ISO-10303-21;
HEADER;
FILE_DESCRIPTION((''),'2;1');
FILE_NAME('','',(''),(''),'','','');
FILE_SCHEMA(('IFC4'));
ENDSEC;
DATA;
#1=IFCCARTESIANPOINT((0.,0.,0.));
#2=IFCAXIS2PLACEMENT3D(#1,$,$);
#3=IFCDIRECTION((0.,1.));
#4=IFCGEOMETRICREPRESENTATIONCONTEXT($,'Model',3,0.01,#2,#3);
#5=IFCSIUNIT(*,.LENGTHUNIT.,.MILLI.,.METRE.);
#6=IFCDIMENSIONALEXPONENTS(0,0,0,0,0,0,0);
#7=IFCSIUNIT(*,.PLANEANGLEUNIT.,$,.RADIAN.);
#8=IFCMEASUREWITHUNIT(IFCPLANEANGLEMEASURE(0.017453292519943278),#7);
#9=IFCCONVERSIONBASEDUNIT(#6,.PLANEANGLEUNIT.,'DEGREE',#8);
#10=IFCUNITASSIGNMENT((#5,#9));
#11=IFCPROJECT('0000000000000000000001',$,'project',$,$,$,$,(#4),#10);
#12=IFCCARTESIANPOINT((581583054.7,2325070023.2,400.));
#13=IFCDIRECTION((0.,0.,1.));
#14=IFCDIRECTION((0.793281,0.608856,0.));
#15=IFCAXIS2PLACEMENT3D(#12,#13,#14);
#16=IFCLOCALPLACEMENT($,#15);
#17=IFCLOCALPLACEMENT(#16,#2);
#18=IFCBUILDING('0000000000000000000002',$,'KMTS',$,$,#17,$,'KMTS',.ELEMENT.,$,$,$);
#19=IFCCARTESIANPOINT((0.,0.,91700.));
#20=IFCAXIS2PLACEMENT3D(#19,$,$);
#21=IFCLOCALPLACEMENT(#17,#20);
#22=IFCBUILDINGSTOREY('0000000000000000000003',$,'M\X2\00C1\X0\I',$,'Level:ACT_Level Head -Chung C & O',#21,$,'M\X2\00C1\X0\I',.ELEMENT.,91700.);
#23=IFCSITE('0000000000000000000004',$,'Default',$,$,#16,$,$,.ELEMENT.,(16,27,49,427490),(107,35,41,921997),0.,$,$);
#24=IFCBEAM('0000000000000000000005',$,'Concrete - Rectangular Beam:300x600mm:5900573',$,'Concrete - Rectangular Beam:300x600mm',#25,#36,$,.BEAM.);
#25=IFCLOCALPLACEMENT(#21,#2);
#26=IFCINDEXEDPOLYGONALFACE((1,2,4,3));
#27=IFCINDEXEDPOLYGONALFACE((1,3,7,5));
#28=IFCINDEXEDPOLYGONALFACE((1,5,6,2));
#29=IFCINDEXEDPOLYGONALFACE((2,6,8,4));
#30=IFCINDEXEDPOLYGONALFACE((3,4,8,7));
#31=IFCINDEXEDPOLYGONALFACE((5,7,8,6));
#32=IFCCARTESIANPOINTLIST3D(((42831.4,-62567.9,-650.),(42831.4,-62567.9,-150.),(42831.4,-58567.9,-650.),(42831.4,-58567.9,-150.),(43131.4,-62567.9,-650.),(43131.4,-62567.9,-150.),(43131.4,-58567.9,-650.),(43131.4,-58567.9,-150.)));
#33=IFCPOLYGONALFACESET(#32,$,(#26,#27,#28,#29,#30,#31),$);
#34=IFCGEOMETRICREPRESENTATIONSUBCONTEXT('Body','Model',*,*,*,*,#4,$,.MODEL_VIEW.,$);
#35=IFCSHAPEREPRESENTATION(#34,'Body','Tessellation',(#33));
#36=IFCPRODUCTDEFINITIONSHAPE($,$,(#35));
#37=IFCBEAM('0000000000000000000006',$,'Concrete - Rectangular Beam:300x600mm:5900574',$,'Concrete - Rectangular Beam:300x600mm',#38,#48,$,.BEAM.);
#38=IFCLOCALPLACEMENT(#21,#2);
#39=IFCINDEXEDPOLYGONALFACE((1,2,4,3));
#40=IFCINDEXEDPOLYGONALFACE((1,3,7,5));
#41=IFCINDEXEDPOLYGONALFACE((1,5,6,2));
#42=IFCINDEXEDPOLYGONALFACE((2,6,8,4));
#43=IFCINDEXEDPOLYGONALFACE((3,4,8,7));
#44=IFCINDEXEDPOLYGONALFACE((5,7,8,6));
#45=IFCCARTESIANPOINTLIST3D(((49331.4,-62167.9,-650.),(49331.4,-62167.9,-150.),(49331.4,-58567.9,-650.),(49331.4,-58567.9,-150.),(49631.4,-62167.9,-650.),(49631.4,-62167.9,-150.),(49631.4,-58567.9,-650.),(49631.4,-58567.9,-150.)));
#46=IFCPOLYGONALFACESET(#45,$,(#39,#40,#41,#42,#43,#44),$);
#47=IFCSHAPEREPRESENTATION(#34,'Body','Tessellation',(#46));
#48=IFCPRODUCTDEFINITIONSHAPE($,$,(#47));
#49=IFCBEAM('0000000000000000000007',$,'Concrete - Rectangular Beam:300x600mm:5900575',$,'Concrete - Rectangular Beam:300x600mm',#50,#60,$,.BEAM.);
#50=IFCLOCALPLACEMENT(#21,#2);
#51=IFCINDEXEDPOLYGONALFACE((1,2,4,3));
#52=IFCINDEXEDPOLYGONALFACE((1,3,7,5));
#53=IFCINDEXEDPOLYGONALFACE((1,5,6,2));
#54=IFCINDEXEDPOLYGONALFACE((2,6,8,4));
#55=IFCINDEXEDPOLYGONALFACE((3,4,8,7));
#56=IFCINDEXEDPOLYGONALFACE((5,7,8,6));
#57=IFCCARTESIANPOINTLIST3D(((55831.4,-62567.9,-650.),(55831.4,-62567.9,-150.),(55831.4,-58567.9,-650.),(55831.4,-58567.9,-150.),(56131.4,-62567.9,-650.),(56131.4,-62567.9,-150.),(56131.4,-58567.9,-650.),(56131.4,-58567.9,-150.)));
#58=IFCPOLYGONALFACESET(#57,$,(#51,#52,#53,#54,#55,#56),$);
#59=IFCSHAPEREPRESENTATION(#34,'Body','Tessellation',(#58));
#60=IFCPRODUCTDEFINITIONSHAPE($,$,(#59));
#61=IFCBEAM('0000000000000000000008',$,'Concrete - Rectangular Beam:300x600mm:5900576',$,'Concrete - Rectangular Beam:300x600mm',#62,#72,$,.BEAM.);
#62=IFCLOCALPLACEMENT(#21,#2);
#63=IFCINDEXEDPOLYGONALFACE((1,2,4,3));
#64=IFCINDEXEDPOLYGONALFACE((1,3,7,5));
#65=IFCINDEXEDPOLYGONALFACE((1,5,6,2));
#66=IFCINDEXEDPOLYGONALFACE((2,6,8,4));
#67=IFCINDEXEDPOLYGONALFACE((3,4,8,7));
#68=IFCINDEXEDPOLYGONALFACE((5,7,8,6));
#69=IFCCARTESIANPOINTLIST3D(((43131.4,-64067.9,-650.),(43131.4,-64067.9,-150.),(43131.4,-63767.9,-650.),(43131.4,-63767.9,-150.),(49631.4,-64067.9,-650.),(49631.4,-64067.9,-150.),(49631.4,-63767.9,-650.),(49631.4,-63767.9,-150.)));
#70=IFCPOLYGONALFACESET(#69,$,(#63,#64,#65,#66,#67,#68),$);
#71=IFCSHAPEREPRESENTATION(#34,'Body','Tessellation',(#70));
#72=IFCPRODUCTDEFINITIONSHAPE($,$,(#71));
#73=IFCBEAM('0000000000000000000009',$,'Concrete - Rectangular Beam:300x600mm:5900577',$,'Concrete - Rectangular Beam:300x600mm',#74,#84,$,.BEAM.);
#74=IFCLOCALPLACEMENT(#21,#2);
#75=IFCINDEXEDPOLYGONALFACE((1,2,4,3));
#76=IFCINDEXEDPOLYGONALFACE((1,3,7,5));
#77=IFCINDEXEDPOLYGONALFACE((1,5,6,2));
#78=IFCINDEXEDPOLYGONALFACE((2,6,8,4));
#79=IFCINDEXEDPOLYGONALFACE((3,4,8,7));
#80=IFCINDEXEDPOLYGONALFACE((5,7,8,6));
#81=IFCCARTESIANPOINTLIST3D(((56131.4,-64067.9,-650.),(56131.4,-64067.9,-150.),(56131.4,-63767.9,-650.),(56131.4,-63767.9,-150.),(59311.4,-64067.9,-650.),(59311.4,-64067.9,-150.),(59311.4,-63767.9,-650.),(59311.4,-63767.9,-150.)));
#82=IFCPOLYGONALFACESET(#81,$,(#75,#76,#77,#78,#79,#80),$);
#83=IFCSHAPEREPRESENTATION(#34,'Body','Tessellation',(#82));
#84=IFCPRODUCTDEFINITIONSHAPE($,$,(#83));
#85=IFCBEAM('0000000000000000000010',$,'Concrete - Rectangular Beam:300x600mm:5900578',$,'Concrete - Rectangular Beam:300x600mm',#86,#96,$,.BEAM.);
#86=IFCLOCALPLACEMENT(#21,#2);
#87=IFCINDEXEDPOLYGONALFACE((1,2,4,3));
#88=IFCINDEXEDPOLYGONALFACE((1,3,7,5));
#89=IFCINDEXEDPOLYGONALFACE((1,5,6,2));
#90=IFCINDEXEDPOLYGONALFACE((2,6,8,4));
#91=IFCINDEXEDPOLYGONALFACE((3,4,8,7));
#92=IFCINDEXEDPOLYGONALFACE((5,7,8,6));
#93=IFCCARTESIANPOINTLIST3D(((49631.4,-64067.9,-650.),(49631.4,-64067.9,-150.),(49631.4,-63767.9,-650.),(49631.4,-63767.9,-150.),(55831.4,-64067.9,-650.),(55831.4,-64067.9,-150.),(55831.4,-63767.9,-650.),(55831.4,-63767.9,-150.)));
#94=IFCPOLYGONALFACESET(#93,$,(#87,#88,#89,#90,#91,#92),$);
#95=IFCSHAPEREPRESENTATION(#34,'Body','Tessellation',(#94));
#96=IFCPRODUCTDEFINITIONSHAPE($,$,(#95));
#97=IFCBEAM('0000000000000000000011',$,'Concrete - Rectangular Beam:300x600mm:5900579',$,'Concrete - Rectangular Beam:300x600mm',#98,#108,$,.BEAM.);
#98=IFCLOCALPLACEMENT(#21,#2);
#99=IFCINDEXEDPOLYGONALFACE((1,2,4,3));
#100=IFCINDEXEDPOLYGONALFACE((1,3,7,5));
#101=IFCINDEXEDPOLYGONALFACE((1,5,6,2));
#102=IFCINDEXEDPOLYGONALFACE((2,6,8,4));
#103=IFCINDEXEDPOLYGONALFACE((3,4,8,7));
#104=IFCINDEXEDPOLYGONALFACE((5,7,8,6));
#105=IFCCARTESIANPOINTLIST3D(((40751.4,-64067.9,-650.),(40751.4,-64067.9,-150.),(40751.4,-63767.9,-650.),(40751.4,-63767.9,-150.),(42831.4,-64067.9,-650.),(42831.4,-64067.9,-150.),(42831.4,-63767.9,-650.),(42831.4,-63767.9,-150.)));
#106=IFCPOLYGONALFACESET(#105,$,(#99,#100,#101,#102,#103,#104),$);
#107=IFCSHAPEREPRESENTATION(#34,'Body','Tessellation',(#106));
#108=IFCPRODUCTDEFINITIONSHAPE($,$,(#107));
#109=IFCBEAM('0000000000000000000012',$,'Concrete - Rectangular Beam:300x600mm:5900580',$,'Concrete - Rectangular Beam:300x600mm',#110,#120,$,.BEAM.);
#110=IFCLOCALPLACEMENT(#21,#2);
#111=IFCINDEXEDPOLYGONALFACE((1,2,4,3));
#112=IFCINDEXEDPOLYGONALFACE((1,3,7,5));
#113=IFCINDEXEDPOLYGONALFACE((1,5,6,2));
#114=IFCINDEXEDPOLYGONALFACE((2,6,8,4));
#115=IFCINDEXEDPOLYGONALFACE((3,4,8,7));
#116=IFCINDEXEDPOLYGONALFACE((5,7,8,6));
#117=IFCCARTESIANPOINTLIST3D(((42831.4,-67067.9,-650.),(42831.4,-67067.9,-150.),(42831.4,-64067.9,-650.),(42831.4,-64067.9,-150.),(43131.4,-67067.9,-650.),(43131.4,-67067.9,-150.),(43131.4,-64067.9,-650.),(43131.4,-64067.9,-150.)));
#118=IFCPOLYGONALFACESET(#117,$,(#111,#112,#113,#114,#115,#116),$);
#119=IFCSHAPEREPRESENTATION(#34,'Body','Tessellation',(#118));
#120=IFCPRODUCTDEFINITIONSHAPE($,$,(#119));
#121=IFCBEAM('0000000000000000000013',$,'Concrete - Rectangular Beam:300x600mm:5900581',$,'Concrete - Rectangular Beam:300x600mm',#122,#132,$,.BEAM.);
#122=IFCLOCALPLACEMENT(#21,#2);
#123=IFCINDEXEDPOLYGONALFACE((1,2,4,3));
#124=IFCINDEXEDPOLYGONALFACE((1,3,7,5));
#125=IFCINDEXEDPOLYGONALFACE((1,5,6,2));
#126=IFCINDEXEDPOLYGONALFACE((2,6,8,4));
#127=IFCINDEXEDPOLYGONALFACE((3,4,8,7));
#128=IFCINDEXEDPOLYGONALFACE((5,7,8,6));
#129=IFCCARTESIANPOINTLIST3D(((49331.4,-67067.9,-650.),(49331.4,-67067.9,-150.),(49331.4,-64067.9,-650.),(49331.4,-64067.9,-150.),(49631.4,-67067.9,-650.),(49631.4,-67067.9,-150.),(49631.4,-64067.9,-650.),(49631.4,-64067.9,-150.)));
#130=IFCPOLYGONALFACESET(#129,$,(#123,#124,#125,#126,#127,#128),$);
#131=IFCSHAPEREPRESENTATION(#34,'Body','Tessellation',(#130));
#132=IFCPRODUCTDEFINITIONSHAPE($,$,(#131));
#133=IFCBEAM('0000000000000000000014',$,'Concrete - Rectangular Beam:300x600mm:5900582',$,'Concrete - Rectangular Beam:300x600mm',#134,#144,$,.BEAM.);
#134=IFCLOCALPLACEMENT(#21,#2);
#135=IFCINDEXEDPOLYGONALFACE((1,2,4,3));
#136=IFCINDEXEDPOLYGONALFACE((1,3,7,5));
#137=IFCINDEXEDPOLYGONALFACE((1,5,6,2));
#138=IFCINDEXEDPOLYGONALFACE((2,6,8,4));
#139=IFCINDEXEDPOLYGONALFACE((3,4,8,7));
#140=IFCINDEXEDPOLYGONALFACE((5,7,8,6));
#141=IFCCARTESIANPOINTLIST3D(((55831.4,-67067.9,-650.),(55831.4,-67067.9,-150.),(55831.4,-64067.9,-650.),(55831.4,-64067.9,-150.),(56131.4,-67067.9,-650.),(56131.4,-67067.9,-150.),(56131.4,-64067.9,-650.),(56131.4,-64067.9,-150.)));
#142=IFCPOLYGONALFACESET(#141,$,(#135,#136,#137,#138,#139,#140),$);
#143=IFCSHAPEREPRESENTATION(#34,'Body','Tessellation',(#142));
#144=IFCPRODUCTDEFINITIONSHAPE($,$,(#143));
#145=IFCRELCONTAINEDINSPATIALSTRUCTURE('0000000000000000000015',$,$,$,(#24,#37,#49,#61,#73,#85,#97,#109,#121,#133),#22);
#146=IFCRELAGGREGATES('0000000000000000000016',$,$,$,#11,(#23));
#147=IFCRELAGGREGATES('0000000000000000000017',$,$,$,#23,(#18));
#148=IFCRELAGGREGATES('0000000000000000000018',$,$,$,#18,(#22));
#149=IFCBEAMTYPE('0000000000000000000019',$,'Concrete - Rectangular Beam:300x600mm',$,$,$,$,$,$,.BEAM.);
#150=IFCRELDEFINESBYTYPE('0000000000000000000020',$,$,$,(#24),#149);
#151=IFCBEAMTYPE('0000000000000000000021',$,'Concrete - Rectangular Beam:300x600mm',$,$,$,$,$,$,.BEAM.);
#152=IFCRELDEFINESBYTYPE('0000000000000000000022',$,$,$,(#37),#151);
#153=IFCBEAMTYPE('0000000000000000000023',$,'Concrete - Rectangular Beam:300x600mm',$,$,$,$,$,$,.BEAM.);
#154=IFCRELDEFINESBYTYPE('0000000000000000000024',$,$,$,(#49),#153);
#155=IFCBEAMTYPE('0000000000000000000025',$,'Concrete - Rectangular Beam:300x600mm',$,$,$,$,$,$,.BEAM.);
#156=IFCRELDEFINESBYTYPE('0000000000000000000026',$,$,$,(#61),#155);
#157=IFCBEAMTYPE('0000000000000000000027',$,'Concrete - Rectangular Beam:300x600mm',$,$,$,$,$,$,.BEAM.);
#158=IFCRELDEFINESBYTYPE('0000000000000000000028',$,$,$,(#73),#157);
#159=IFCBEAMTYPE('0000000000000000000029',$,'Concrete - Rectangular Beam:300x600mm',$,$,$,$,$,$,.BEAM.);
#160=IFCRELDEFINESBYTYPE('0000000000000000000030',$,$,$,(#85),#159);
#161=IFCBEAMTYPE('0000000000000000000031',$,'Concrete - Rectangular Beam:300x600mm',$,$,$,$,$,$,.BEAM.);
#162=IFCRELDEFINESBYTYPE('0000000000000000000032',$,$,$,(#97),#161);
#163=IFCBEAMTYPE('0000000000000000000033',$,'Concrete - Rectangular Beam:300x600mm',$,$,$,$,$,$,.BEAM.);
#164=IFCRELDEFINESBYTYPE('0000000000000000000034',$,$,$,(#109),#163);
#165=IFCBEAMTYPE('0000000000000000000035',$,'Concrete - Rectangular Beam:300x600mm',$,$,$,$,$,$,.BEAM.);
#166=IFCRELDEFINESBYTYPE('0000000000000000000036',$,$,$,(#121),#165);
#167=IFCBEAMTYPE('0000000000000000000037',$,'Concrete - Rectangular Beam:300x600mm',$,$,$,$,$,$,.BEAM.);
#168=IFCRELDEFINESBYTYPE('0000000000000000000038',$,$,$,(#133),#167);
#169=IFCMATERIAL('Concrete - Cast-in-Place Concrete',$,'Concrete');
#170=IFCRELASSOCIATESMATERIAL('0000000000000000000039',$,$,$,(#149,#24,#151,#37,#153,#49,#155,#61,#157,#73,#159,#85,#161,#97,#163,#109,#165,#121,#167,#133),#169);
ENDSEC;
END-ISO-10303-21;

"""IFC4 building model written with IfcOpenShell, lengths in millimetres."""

from ifc_helpers import new_model, entity, si_unit, converted_unit, direction, frame, origin, place, context, subcontext, project, spatial, indexed_curve, outline, extrude, source, transform, mapped, material, type_object, type_shapes, element, save


model = new_model("IFC4")

# Units and contexts
model_context = context("Model", 3, precision=0.01, world=origin(), true_north=direction((0.0, 1.0)))
body_context = subcontext(model_context, "Body", "Model", "MODEL_VIEW")
ifc_project = project(units=[si_unit("LENGTHUNIT", "METRE", prefix="MILLI"), converted_unit("PLANEANGLEUNIT", "DEGREE", entity("IfcPlaneAngleMeasure", 0.017453292519943278), si_unit("PLANEANGLEUNIT", "RADIAN"), dimensions=[0, 0, 0, 0, 0, 0, 0])], contexts=[model_context])

# Site, building, storey
site_placement = place(None, frame((581583054.7, 2325070023.2, 400.0), z_axis=(0.0, 0.0, 1.0), x_axis=(0.793281, 0.608856, 0.0)))
site = spatial("IfcSite", under=ifc_project, at=site_placement, Name="Default", CompositionType="ELEMENT", RefLatitude=(16, 27, 49, 427490), RefLongitude=(107, 35, 41, 921997), RefElevation=0.0)
building_placement = place(site_placement, origin())
building = spatial("IfcBuilding", under=site, at=building_placement, Name="KMTS", LongName="KMTS", CompositionType="ELEMENT")
storey_placement = place(building_placement, frame((0.0, 0.0, 91700.0)))
storey = spatial("IfcBuildingStorey", under=building, at=storey_placement, Name="MÁI", ObjectType="Level:ACT_Level Head -Chung C & O", LongName="MÁI", CompositionType="ELEMENT", Elevation=91700.0)

# Beams
ifc_material_1 = material(Name="Concrete - Cast-in-Place Concrete", Category="Concrete")
beam_type_1 = type_object("IfcBeamType", Name="Concrete - Rectangular Beam:300x600mm", PredefinedType="BEAM", material=ifc_material_1)
shared_shape_1 = source(origin(), body_context, "Body", "SweptSolid", [
    extrude(outline(indexed_curve([(-150.0, -250.0), (150.0, -250.0), (150.0, 250.0), (-150.0, 250.0), (-150.0, -250.0)], self_intersect=False)), frame((42981.4, -58567.9, 91300.0), z_axis=(0.0, -1.0, 0.0), x_axis=(-1.0, 0.0, 0.0)), (0.0, 0.0, 1.0), 4000.0),
])
type_shapes(beam_type_1, [shared_shape_1])
beam_1_placement = place(storey_placement, frame((0.0, 0.0, -91700.0)))
element("IfcBeam", 1, at=beam_1_placement, inside=storey, type_object=beam_type_1, material=ifc_material_1, Name="Concrete - Rectangular Beam:300x600mm:5900573", ObjectType="Concrete - Rectangular Beam:300x600mm", PredefinedType="BEAM", context=body_context, shape_type="MappedRepresentation", body=[
    mapped(shared_shape_1, transform((0.0, 0.0, 0.0), scale=1.0)),
])
beam_type_2 = type_object("IfcBeamType", Name="Concrete - Rectangular Beam:300x600mm", PredefinedType="BEAM", material=ifc_material_1)
shared_shape_2 = source(origin(), body_context, "Body", "SweptSolid", [
    extrude(outline(indexed_curve([(-150.0, -250.0), (150.0, -250.0), (150.0, 250.0), (-150.0, 250.0), (-150.0, -250.0)], self_intersect=False)), frame((49481.4, -58567.9, 91300.0), z_axis=(0.0, -1.0, 0.0), x_axis=(-1.0, 0.0, 0.0)), (0.0, 0.0, 1.0), 3600.0),
])
type_shapes(beam_type_2, [shared_shape_2])
beam_2_placement = place(storey_placement, frame((0.0, 0.0, -91700.0)))
element("IfcBeam", 2, at=beam_2_placement, inside=storey, type_object=beam_type_2, material=ifc_material_1, Name="Concrete - Rectangular Beam:300x600mm:5900574", ObjectType="Concrete - Rectangular Beam:300x600mm", PredefinedType="BEAM", context=body_context, shape_type="MappedRepresentation", body=[
    mapped(shared_shape_2, transform((0.0, 0.0, 0.0), scale=1.0)),
])
beam_type_3 = type_object("IfcBeamType", Name="Concrete - Rectangular Beam:300x600mm", PredefinedType="BEAM", material=ifc_material_1)
shared_shape_3 = source(origin(), body_context, "Body", "SweptSolid", [
    extrude(outline(indexed_curve([(-150.0, -250.0), (150.0, -250.0), (150.0, 250.0), (-150.0, 250.0), (-150.0, -250.0)], self_intersect=False)), frame((55981.4, -58567.9, 91300.0), z_axis=(0.0, -1.0, 0.0), x_axis=(-1.0, 0.0, 0.0)), (0.0, 0.0, 1.0), 4000.0),
])
type_shapes(beam_type_3, [shared_shape_3])
beam_3_placement = place(storey_placement, frame((0.0, 0.0, -91700.0)))
element("IfcBeam", 3, at=beam_3_placement, inside=storey, type_object=beam_type_3, material=ifc_material_1, Name="Concrete - Rectangular Beam:300x600mm:5900575", ObjectType="Concrete - Rectangular Beam:300x600mm", PredefinedType="BEAM", context=body_context, shape_type="MappedRepresentation", body=[
    mapped(shared_shape_3, transform((0.0, 0.0, 0.0), scale=1.0)),
])
beam_type_4 = type_object("IfcBeamType", Name="Concrete - Rectangular Beam:300x600mm", PredefinedType="BEAM", material=ifc_material_1)
shared_shape_4 = source(origin(), body_context, "Body", "SweptSolid", [
    extrude(outline(indexed_curve([(-250.0, -150.0), (250.0, -150.0), (250.0, 150.0), (-250.0, 150.0), (-250.0, -150.0)], self_intersect=False)), frame((49631.4, -63917.9, 91300.0), z_axis=(-1.0, 0.0, 0.0), x_axis=(0.0, 0.0, -1.0)), (0.0, 0.0, 1.0), 6500.0),
])
type_shapes(beam_type_4, [shared_shape_4])
beam_4_placement = place(storey_placement, frame((0.0, 0.0, -91700.0)))
element("IfcBeam", 4, at=beam_4_placement, inside=storey, type_object=beam_type_4, material=ifc_material_1, Name="Concrete - Rectangular Beam:300x600mm:5900576", ObjectType="Concrete - Rectangular Beam:300x600mm", PredefinedType="BEAM", context=body_context, shape_type="MappedRepresentation", body=[
    mapped(shared_shape_4, transform((0.0, 0.0, 0.0), scale=1.0)),
])
beam_type_5 = type_object("IfcBeamType", Name="Concrete - Rectangular Beam:300x600mm", PredefinedType="BEAM", material=ifc_material_1)
shared_shape_5 = source(origin(), body_context, "Body", "SweptSolid", [
    extrude(outline(indexed_curve([(-250.0, -150.0), (250.0, -150.0), (250.0, 150.0), (-250.0, 150.0), (-250.0, -150.0)], self_intersect=False)), frame((56131.4, -63917.9, 91300.0), z_axis=(1.0, 0.0, 0.0), x_axis=(0.0, 0.0, -1.0)), (0.0, 0.0, 1.0), 3180.0),
])
type_shapes(beam_type_5, [shared_shape_5])
beam_5_placement = place(storey_placement, frame((0.0, 0.0, -91700.0)))
element("IfcBeam", 5, at=beam_5_placement, inside=storey, type_object=beam_type_5, material=ifc_material_1, Name="Concrete - Rectangular Beam:300x600mm:5900577", ObjectType="Concrete - Rectangular Beam:300x600mm", PredefinedType="BEAM", context=body_context, shape_type="MappedRepresentation", body=[
    mapped(shared_shape_5, transform((0.0, 0.0, 0.0), scale=1.0)),
])
beam_type_6 = type_object("IfcBeamType", Name="Concrete - Rectangular Beam:300x600mm", PredefinedType="BEAM", material=ifc_material_1)
shared_shape_6 = source(origin(), body_context, "Body", "SweptSolid", [
    extrude(outline(indexed_curve([(-250.0, -150.0), (250.0, -150.0), (250.0, 150.0), (-250.0, 150.0), (-250.0, -150.0)], self_intersect=False)), frame((49631.4, -63917.9, 91300.0), z_axis=(1.0, 0.0, 0.0), x_axis=(0.0, 0.0, -1.0)), (0.0, 0.0, 1.0), 6200.0),
])
type_shapes(beam_type_6, [shared_shape_6])
beam_6_placement = place(storey_placement, frame((0.0, 0.0, -91700.0)))
element("IfcBeam", 6, at=beam_6_placement, inside=storey, type_object=beam_type_6, material=ifc_material_1, Name="Concrete - Rectangular Beam:300x600mm:5900578", ObjectType="Concrete - Rectangular Beam:300x600mm", PredefinedType="BEAM", context=body_context, shape_type="MappedRepresentation", body=[
    mapped(shared_shape_6, transform((0.0, 0.0, 0.0), scale=1.0)),
])
beam_type_7 = type_object("IfcBeamType", Name="Concrete - Rectangular Beam:300x600mm", PredefinedType="BEAM", material=ifc_material_1)
shared_shape_7 = source(origin(), body_context, "Body", "SweptSolid", [
    extrude(outline(indexed_curve([(-250.0, -150.0), (250.0, -150.0), (250.0, 150.0), (-250.0, 150.0), (-250.0, -150.0)], self_intersect=False)), frame((42831.4, -63917.9, 91300.0), z_axis=(-1.0, 0.0, 0.0), x_axis=(0.0, 0.0, -1.0)), (0.0, 0.0, 1.0), 2080.0),
])
type_shapes(beam_type_7, [shared_shape_7])
beam_7_placement = place(storey_placement, frame((0.0, 0.0, -91700.0)))
element("IfcBeam", 7, at=beam_7_placement, inside=storey, type_object=beam_type_7, material=ifc_material_1, Name="Concrete - Rectangular Beam:300x600mm:5900579", ObjectType="Concrete - Rectangular Beam:300x600mm", PredefinedType="BEAM", context=body_context, shape_type="MappedRepresentation", body=[
    mapped(shared_shape_7, transform((0.0, 0.0, 0.0), scale=1.0)),
])
beam_type_8 = type_object("IfcBeamType", Name="Concrete - Rectangular Beam:300x600mm", PredefinedType="BEAM", material=ifc_material_1)
shared_shape_8 = source(origin(), body_context, "Body", "SweptSolid", [
    extrude(outline(indexed_curve([(-150.0, -250.0), (150.0, -250.0), (150.0, 250.0), (-150.0, 250.0), (-150.0, -250.0)], self_intersect=False)), frame((42981.4, -64067.9, 91300.0), z_axis=(0.0, -1.0, 0.0), x_axis=(-1.0, 0.0, 0.0)), (0.0, 0.0, 1.0), 3000.0),
])
type_shapes(beam_type_8, [shared_shape_8])
beam_8_placement = place(storey_placement, frame((0.0, 0.0, -91700.0)))
element("IfcBeam", 8, at=beam_8_placement, inside=storey, type_object=beam_type_8, material=ifc_material_1, Name="Concrete - Rectangular Beam:300x600mm:5900580", ObjectType="Concrete - Rectangular Beam:300x600mm", PredefinedType="BEAM", context=body_context, shape_type="MappedRepresentation", body=[
    mapped(shared_shape_8, transform((0.0, 0.0, 0.0), scale=1.0)),
])
beam_type_9 = type_object("IfcBeamType", Name="Concrete - Rectangular Beam:300x600mm", PredefinedType="BEAM", material=ifc_material_1)
shared_shape_9 = source(origin(), body_context, "Body", "SweptSolid", [
    extrude(outline(indexed_curve([(-150.0, -250.0), (150.0, -250.0), (150.0, 250.0), (-150.0, 250.0), (-150.0, -250.0)], self_intersect=False)), frame((49481.4, -64067.9, 91300.0), z_axis=(0.0, -1.0, 0.0), x_axis=(-1.0, 0.0, 0.0)), (0.0, 0.0, 1.0), 3000.0),
])
type_shapes(beam_type_9, [shared_shape_9])
beam_9_placement = place(storey_placement, frame((0.0, 0.0, -91700.0)))
element("IfcBeam", 9, at=beam_9_placement, inside=storey, type_object=beam_type_9, material=ifc_material_1, Name="Concrete - Rectangular Beam:300x600mm:5900581", ObjectType="Concrete - Rectangular Beam:300x600mm", PredefinedType="BEAM", context=body_context, shape_type="MappedRepresentation", body=[
    mapped(shared_shape_9, transform((0.0, 0.0, 0.0), scale=1.0)),
])
beam_type_10 = type_object("IfcBeamType", Name="Concrete - Rectangular Beam:300x600mm", PredefinedType="BEAM", material=ifc_material_1)
shared_shape_10 = source(origin(), body_context, "Body", "SweptSolid", [
    extrude(outline(indexed_curve([(-150.0, -250.0), (150.0, -250.0), (150.0, 250.0), (-150.0, 250.0), (-150.0, -250.0)], self_intersect=False)), frame((55981.4, -64067.9, 91300.0), z_axis=(0.0, -1.0, 0.0), x_axis=(-1.0, 0.0, 0.0)), (0.0, 0.0, 1.0), 3000.0),
])
type_shapes(beam_type_10, [shared_shape_10])
beam_10_placement = place(storey_placement, frame((0.0, 0.0, -91700.0)))
element("IfcBeam", 10, at=beam_10_placement, inside=storey, type_object=beam_type_10, material=ifc_material_1, Name="Concrete - Rectangular Beam:300x600mm:5900582", ObjectType="Concrete - Rectangular Beam:300x600mm", PredefinedType="BEAM", context=body_context, shape_type="MappedRepresentation", body=[
    mapped(shared_shape_10, transform((0.0, 0.0, 0.0), scale=1.0)),
])

save(model, "model.ifc")
